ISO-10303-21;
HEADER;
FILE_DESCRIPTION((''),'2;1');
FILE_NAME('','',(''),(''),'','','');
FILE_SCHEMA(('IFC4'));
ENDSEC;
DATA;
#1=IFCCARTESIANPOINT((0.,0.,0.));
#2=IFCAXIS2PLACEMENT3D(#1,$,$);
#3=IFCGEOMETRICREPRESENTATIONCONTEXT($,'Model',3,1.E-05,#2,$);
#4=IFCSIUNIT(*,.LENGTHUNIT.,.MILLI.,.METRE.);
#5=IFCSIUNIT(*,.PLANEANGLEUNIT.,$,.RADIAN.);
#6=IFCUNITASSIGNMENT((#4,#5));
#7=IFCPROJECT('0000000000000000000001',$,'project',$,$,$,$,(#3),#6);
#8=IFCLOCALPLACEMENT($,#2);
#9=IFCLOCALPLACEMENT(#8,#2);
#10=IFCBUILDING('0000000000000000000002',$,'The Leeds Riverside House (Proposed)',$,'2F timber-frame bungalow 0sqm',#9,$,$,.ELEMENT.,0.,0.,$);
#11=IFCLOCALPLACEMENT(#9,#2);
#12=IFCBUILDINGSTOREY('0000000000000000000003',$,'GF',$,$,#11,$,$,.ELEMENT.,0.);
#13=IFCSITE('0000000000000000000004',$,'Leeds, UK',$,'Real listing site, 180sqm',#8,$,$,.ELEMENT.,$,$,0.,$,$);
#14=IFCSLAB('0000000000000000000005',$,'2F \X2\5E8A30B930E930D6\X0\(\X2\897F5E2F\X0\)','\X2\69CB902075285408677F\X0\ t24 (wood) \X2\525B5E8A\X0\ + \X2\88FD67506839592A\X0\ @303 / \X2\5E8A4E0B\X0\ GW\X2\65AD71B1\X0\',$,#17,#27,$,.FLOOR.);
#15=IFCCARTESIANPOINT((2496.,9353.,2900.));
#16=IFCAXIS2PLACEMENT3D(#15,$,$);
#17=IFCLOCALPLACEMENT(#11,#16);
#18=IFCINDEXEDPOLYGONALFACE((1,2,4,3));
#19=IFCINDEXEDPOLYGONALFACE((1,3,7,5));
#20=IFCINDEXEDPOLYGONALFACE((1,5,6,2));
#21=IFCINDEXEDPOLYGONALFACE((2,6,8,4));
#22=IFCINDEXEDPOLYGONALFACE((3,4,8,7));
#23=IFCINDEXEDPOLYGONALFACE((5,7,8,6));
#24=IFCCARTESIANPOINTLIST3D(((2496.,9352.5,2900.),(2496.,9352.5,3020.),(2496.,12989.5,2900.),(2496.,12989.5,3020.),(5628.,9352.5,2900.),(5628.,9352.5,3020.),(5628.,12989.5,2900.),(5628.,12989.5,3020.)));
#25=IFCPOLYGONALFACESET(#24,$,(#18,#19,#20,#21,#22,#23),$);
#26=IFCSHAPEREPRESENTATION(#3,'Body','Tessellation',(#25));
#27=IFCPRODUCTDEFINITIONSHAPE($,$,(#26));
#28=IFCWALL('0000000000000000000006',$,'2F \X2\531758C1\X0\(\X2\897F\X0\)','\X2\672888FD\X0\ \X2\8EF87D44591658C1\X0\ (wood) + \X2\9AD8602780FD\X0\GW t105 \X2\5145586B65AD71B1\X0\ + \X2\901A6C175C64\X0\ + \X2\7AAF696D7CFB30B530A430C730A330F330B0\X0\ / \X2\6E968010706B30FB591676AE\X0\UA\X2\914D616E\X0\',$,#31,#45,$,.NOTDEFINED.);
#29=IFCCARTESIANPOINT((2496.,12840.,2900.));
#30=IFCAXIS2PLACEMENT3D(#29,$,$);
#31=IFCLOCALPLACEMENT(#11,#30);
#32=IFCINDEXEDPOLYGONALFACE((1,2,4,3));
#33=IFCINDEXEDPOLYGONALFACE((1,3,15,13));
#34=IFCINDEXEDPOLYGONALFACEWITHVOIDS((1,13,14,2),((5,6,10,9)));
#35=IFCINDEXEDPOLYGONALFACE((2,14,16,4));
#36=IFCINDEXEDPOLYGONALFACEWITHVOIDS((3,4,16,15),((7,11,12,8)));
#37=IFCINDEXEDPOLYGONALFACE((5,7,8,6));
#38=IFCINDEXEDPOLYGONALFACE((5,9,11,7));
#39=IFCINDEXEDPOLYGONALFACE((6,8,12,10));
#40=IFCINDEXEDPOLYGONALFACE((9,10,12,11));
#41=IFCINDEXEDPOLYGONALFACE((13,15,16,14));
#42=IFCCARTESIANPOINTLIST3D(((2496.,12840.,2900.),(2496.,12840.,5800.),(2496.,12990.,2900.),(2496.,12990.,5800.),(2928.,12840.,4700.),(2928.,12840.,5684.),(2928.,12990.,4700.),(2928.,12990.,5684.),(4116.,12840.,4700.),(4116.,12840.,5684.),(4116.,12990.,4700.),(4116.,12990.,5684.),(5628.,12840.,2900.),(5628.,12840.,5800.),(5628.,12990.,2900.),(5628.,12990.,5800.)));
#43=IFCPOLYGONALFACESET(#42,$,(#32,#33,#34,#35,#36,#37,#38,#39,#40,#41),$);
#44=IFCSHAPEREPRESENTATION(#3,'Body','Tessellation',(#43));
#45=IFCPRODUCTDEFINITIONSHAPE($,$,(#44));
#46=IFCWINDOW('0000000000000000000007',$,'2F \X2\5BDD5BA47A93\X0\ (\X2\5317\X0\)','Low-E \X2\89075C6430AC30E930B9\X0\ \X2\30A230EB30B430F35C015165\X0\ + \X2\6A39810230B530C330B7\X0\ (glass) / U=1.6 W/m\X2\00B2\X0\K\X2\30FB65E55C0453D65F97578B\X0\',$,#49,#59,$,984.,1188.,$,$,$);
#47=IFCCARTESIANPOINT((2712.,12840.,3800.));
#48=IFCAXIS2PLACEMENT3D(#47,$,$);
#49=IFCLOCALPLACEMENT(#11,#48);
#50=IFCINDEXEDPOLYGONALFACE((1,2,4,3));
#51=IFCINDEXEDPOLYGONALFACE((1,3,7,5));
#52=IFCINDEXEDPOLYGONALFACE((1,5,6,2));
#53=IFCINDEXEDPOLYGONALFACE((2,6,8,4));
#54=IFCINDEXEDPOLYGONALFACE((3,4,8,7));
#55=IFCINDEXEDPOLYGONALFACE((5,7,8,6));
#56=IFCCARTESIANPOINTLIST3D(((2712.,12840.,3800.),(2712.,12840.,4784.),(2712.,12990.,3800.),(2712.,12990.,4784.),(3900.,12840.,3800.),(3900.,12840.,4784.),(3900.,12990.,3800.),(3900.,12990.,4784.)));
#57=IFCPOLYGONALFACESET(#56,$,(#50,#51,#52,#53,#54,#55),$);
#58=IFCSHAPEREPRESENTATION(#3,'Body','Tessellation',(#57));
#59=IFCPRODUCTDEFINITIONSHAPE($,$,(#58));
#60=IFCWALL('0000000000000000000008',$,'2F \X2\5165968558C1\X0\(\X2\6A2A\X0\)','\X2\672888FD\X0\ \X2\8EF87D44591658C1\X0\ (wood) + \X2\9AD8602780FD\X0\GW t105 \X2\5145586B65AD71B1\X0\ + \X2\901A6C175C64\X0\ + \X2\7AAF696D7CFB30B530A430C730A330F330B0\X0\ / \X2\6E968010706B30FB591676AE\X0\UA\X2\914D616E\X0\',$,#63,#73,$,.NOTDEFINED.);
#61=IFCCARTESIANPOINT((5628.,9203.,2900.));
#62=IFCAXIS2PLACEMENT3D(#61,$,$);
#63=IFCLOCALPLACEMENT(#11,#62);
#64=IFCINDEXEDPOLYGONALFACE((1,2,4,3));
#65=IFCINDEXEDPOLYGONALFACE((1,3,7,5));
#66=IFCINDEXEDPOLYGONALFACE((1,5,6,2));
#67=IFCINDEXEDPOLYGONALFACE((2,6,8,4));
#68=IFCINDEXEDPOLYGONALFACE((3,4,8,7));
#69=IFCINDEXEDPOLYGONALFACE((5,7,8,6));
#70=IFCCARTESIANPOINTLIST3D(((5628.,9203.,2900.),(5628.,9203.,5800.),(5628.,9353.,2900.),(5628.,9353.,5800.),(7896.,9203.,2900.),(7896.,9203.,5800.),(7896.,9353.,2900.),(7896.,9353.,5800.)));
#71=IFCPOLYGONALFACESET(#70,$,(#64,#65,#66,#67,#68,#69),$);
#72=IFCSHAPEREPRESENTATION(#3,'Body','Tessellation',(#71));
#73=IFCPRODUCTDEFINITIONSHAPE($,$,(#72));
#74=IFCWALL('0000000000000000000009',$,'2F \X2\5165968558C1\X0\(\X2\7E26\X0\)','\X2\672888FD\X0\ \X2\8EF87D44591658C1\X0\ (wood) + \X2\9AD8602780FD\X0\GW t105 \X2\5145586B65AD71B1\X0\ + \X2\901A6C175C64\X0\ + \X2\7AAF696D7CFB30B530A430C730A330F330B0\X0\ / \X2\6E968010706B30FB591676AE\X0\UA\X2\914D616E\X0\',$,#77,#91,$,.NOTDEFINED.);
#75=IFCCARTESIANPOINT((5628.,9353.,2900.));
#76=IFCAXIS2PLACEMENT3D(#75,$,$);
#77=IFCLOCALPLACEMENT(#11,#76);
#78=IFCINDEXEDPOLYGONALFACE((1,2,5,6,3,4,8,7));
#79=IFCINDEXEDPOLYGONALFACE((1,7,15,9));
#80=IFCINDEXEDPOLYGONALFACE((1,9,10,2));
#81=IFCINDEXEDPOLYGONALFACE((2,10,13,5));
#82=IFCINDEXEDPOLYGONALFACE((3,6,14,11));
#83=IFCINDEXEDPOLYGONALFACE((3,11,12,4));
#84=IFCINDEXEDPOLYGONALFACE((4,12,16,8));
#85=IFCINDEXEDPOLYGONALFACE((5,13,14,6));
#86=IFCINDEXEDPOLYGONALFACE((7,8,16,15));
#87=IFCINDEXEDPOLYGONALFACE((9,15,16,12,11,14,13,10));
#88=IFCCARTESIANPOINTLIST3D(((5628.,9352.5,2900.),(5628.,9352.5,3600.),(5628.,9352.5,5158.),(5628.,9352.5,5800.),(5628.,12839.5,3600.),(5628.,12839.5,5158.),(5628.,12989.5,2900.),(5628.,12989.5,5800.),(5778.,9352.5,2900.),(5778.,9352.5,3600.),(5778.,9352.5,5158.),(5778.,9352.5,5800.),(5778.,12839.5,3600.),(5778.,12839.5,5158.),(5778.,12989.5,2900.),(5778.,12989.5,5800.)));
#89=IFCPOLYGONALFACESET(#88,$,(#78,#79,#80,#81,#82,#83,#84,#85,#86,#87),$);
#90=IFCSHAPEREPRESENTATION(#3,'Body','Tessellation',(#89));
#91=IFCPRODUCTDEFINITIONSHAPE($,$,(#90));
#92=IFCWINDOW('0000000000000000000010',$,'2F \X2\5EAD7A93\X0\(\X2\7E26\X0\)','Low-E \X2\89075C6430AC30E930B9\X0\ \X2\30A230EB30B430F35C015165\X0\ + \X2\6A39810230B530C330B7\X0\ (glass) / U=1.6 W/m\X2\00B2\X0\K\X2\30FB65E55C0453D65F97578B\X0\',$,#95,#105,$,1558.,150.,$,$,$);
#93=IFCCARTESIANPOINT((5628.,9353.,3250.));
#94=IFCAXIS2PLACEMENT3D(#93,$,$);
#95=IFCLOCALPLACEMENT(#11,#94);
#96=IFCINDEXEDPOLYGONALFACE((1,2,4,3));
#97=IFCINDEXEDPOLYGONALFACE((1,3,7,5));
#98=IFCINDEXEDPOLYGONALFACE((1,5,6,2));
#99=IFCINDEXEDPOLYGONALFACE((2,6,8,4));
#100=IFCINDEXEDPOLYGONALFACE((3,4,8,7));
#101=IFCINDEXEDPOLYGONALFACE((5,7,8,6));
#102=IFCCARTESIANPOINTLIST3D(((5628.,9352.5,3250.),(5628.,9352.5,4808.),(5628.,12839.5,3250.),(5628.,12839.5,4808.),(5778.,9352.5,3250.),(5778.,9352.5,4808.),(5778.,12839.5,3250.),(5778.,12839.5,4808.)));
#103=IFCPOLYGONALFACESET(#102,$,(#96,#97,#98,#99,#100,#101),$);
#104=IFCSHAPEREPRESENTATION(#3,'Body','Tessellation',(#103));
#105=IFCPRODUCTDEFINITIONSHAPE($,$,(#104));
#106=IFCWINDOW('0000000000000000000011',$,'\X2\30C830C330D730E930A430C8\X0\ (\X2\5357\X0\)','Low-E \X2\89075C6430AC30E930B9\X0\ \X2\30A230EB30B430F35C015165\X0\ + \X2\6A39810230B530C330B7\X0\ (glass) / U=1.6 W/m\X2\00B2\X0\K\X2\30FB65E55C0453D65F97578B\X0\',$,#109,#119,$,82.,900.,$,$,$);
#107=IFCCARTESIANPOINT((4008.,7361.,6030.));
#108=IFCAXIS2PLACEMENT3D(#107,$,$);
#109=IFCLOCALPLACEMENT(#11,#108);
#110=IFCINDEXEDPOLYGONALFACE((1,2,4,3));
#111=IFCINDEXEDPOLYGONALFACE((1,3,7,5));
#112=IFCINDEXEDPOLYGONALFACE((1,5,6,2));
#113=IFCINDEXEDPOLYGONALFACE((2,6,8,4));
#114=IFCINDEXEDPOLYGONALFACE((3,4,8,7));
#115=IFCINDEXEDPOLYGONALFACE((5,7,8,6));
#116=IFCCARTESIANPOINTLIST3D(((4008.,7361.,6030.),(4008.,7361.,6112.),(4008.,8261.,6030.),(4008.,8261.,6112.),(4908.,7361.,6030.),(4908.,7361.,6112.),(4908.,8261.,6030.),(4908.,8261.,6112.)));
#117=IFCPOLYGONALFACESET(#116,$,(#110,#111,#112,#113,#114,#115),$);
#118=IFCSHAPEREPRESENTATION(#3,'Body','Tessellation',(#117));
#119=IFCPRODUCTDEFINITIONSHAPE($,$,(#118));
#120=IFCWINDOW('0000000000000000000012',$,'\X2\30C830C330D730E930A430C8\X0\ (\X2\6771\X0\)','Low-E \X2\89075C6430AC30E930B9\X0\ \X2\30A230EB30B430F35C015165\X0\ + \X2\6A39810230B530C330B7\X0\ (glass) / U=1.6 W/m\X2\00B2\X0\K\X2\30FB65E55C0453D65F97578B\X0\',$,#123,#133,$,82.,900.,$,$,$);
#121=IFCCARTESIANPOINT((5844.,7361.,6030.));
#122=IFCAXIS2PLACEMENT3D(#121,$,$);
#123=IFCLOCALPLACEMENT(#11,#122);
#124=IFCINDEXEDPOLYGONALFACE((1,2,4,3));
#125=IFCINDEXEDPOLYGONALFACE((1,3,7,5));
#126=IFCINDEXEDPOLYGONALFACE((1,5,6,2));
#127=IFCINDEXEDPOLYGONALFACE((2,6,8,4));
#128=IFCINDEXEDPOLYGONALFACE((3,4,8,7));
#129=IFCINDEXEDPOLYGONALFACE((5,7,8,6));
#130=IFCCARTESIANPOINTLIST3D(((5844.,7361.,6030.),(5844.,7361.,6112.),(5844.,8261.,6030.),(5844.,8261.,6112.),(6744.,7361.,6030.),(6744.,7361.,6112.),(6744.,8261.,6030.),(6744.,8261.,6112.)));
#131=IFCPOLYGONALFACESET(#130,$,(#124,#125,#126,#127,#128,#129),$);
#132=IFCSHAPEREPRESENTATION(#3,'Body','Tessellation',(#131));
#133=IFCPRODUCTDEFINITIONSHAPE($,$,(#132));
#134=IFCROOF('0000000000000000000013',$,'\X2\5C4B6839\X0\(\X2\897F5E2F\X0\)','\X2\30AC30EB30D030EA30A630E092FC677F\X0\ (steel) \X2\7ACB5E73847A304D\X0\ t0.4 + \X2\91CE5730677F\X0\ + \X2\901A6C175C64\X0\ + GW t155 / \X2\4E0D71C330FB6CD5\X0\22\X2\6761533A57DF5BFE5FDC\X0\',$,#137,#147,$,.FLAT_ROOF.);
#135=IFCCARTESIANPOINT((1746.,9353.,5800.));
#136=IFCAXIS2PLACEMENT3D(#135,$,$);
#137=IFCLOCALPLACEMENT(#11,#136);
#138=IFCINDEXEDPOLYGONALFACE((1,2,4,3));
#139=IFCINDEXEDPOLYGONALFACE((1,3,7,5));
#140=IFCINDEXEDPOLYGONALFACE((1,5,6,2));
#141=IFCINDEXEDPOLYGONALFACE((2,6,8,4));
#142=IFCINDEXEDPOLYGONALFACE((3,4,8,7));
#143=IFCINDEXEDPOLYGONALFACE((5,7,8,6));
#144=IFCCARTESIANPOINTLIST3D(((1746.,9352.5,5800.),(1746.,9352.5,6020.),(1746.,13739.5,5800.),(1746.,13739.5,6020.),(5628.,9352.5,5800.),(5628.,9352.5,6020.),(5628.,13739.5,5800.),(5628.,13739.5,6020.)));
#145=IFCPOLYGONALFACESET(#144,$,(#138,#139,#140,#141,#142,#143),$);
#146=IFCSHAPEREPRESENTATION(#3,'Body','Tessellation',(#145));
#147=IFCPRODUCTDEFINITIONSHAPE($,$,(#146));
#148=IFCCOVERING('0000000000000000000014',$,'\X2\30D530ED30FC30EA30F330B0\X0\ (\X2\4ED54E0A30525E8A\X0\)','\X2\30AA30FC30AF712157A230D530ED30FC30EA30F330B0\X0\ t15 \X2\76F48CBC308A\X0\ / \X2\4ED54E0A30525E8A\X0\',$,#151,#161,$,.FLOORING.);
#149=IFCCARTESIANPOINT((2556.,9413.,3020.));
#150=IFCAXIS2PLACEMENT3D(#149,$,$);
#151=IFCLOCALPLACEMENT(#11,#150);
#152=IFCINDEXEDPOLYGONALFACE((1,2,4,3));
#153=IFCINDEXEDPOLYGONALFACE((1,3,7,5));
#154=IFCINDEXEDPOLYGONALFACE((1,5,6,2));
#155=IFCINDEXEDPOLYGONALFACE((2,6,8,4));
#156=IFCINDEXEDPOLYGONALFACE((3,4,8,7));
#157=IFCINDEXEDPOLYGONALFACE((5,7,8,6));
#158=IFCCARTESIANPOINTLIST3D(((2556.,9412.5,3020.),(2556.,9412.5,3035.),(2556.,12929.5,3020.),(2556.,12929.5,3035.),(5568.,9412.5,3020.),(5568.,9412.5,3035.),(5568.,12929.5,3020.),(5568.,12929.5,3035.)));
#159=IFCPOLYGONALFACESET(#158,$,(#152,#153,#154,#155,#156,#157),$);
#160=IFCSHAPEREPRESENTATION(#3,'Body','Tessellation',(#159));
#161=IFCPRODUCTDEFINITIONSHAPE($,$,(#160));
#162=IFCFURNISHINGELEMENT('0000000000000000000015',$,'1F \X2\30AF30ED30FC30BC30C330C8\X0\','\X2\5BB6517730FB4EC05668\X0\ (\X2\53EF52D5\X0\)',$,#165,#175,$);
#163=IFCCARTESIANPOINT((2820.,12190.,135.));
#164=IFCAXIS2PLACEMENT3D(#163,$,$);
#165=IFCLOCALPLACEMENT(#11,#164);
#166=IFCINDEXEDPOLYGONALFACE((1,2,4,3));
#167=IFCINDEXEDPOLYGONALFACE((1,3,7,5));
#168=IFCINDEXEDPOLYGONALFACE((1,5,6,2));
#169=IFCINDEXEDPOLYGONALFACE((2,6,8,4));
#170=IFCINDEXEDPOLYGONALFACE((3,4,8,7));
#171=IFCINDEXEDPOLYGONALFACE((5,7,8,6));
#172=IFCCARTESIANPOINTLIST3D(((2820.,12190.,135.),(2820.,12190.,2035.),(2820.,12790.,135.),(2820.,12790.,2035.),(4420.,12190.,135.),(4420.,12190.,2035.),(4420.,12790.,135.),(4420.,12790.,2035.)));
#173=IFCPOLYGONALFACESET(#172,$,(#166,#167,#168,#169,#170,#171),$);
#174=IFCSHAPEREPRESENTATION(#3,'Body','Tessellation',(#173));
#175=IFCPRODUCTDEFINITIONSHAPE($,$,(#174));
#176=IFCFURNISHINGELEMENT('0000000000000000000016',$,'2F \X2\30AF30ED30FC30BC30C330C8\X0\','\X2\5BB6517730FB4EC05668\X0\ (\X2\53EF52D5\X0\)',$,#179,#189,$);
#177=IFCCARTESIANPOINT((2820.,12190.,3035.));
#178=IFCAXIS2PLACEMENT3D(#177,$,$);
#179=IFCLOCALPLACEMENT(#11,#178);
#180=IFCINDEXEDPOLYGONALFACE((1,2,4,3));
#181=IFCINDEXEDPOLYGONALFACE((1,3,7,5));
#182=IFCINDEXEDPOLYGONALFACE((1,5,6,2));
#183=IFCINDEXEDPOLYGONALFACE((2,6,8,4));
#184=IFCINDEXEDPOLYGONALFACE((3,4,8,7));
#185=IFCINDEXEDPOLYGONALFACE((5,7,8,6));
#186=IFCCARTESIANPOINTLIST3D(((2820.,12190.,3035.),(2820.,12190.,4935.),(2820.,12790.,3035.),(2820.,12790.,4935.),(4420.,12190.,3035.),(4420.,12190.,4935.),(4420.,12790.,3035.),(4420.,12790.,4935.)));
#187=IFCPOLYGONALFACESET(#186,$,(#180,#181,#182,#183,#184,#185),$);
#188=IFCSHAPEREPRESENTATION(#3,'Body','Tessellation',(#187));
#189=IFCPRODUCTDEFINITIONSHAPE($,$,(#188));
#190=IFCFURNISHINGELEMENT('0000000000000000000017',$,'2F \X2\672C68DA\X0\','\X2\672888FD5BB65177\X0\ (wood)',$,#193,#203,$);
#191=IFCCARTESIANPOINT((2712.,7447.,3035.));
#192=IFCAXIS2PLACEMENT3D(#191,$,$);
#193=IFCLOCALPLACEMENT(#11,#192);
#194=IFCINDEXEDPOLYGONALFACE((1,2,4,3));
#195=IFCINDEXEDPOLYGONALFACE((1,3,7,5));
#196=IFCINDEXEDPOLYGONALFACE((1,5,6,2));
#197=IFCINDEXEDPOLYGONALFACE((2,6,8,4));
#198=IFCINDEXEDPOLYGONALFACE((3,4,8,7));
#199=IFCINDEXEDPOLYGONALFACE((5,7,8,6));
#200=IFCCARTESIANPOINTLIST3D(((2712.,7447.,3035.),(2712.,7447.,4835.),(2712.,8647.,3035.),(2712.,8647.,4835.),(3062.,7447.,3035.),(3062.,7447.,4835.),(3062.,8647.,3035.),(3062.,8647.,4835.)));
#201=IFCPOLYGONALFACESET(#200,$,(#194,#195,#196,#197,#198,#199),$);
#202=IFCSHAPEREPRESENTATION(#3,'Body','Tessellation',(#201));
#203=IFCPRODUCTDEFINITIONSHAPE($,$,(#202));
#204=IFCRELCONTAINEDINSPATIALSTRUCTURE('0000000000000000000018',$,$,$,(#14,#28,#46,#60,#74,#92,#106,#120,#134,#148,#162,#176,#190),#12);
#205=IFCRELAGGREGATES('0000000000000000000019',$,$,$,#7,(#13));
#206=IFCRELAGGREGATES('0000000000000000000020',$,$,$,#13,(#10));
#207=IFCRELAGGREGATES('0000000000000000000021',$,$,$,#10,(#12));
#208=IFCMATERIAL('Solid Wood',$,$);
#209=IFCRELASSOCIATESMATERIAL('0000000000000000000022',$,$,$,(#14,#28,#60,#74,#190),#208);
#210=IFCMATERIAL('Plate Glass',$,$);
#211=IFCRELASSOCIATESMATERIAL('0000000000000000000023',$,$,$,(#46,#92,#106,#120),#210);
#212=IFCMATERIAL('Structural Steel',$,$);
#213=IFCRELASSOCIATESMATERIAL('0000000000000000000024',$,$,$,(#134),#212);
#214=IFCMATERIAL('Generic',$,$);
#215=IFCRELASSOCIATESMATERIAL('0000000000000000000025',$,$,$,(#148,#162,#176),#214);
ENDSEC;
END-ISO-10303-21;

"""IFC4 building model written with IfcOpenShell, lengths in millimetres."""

from ifc_helpers import new_model, si_unit, frame, frame_2d, origin, place, context, project, spatial, rectangle, extrude, material, element, fill, save


model = new_model("IFC4")

# Units and contexts
model_context = context("Model", 3, precision=1e-05, world=origin())
ifc_project = project(units=[si_unit("LENGTHUNIT", "METRE", prefix="MILLI"), si_unit("PLANEANGLEUNIT", "RADIAN")], contexts=[model_context])

# Site, building, storey
site_placement = place(None, origin())
site = spatial("IfcSite", under=ifc_project, at=site_placement, Name="Leeds, UK", ObjectType="Real listing site, 180sqm", CompositionType="ELEMENT", RefElevation=0.0)
building_placement = place(site_placement, origin())
building = spatial("IfcBuilding", under=site, at=building_placement, Name="The Leeds Riverside House (Proposed)", ObjectType="2F timber-frame bungalow 0sqm", CompositionType="ELEMENT", ElevationOfRefHeight=0.0, ElevationOfTerrain=0.0)
storey_placement = place(building_placement, origin())
storey = spatial("IfcBuildingStorey", under=building, at=storey_placement, Name="GF", CompositionType="ELEMENT", Elevation=0.0)

# Slab
ifc_material_1 = material(Name="Solid Wood")
slab_placement = place(storey_placement, frame((2496.0, 9353.0, 2900.0)))
element("IfcSlab", 1, at=slab_placement, inside=storey, material=ifc_material_1, Name="2F 床スラブ(西帯)", Description="構造用合板 t24 (wood) 剛床 + 製材根太 @303 / 床下 GW断熱", PredefinedType="FLOOR", context=model_context, shape_type="SweptSolid", body=[
    extrude(rectangle(XDim=3132.0, YDim=3637.0, at=frame_2d((1566.0, 1818.0))), frame((2496.0, 9353.0, 2900.0)), (0.0, 0.0, 1.0), 120.0),
])

# Wall, opening, window
wall_1_placement = place(storey_placement, frame((2496.0, 12840.0, 2900.0)))
wall_1 = element("IfcWall", 2, at=wall_1_placement, inside=storey, material=ifc_material_1, Name="2F 北壁(西)", Description="木製 軸組外壁 (wood) + 高性能GW t105 充填断熱 + 通気層 + 窯業系サイディング / 準耐火・外皮UA配慮", PredefinedType="NOTDEFINED", context=model_context, shape_type="SweptSolid", body=[
    extrude(rectangle(XDim=3132.0, YDim=150.0, at=frame_2d((1566.0, 75.0))), frame((2496.0, 12840.0, 2900.0)), (0.0, 0.0, 1.0), 2900.0),
])
opening_1_placement = place(storey_placement, frame((2712.0, 12840.0, 3800.0)))
opening_1 = element("IfcOpeningElement", 3, at=opening_1_placement, cuts=wall_1, PredefinedType="NOTDEFINED", context=model_context, shape_type="SweptSolid", body=[
    extrude(rectangle(XDim=1188.0, YDim=150.0, at=frame_2d((594.0, 75.0))), frame((2712.0, 12840.0, 3800.0)), (0.0, 0.0, 1.0), 984.0),
])
ifc_material_2 = material(Name="Plate Glass")
window_1_placement = place(storey_placement, frame((2712.0, 12840.0, 3800.0)))
window_1 = element("IfcWindow", 4, at=window_1_placement, inside=storey, material=ifc_material_2, Name="2F 寝室窓 (北)", Description="Low-E 複層ガラス アルゴン封入 + 樹脂サッシ (glass) / U=1.6 W/m²K・日射取得型", OverallHeight=984.0, OverallWidth=1188.0, context=model_context, shape_type="SweptSolid", body=[
    extrude(rectangle(XDim=1188.0, YDim=150.0, at=frame_2d((594.0, 75.0))), frame((2712.0, 12840.0, 3800.0)), (0.0, 0.0, 1.0), 984.0),
])
fill(opening_1, window_1)

# Wall
wall_2_placement = place(storey_placement, frame((5628.0, 9203.0, 2900.0)))
element("IfcWall", 5, at=wall_2_placement, inside=storey, material=ifc_material_1, Name="2F 入隅壁(横)", Description="木製 軸組外壁 (wood) + 高性能GW t105 充填断熱 + 通気層 + 窯業系サイディング / 準耐火・外皮UA配慮", PredefinedType="NOTDEFINED", context=model_context, shape_type="SweptSolid", body=[
    extrude(rectangle(XDim=2268.0, YDim=150.0, at=frame_2d((1134.0, 75.0))), frame((5628.0, 9203.0, 2900.0)), (0.0, 0.0, 1.0), 2900.0),
])

# Wall, opening, window
wall_3_placement = place(storey_placement, frame((5628.0, 9353.0, 2900.0)))
wall_3 = element("IfcWall", 6, at=wall_3_placement, inside=storey, material=ifc_material_1, Name="2F 入隅壁(縦)", Description="木製 軸組外壁 (wood) + 高性能GW t105 充填断熱 + 通気層 + 窯業系サイディング / 準耐火・外皮UA配慮", PredefinedType="NOTDEFINED", context=model_context, shape_type="SweptSolid", body=[
    extrude(rectangle(XDim=150.0, YDim=3637.0, at=frame_2d((75.0, 1818.0))), frame((5628.0, 9353.0, 2900.0)), (0.0, 0.0, 1.0), 2900.0),
])
opening_2_placement = place(storey_placement, frame((5628.0, 9353.0, 3250.0)))
opening_2 = element("IfcOpeningElement", 7, at=opening_2_placement, cuts=wall_3, PredefinedType="NOTDEFINED", context=model_context, shape_type="SweptSolid", body=[
    extrude(rectangle(XDim=150.0, YDim=3487.0, at=frame_2d((75.0, 1743.0))), frame((5628.0, 9353.0, 3250.0)), (0.0, 0.0, 1.0), 1558.0),
])
window_2_placement = place(storey_placement, frame((5628.0, 9353.0, 3250.0)))
window_2 = element("IfcWindow", 8, at=window_2_placement, inside=storey, material=ifc_material_2, Name="2F 庭窓(縦)", Description="Low-E 複層ガラス アルゴン封入 + 樹脂サッシ (glass) / U=1.6 W/m²K・日射取得型", OverallHeight=1558.0, OverallWidth=150.0, context=model_context, shape_type="SweptSolid", body=[
    extrude(rectangle(XDim=150.0, YDim=3487.0, at=frame_2d((75.0, 1743.0))), frame((5628.0, 9353.0, 3250.0)), (0.0, 0.0, 1.0), 1558.0),
])
fill(opening_2, window_2)

# Windows
window_3_placement = place(storey_placement, frame((4008.0, 7361.0, 6030.0)))
element("IfcWindow", 9, at=window_3_placement, inside=storey, material=ifc_material_2, Name="トップライト (南)", Description="Low-E 複層ガラス アルゴン封入 + 樹脂サッシ (glass) / U=1.6 W/m²K・日射取得型", OverallHeight=82.0, OverallWidth=900.0, context=model_context, shape_type="SweptSolid", body=[
    extrude(rectangle(XDim=900.0, YDim=900.0, at=frame_2d((450.0, 450.0))), frame((4008.0, 7361.0, 6030.0)), (0.0, 0.0, 1.0), 82.0),
])
window_4_placement = place(storey_placement, frame((5844.0, 7361.0, 6030.0)))
element("IfcWindow", 10, at=window_4_placement, inside=storey, material=ifc_material_2, Name="トップライト (東)", Description="Low-E 複層ガラス アルゴン封入 + 樹脂サッシ (glass) / U=1.6 W/m²K・日射取得型", OverallHeight=82.0, OverallWidth=900.0, context=model_context, shape_type="SweptSolid", body=[
    extrude(rectangle(XDim=900.0, YDim=900.0, at=frame_2d((450.0, 450.0))), frame((5844.0, 7361.0, 6030.0)), (0.0, 0.0, 1.0), 82.0),
])

# Roof
ifc_material_3 = material(Name="Structural Steel")
for number, where, name in (
    (11, (1746.0, 9353.0, 5800.0), "屋根(西帯)"),
):
    element("IfcRoof", number, at=place(storey_placement, frame(where)), inside=storey, material=ifc_material_3, Name=name, Description="ガルバリウム鋼板 (steel) 立平葺き t0.4 + 野地板 + 通気層 + GW t155 / 不燃・法22条区域対応", PredefinedType="FLAT_ROOF", context=model_context, shape_type="SweptSolid", body=[
        extrude(rectangle(XDim=3882.0, YDim=4387.0, at=frame_2d((1941.0, 2193.0))), frame((1746.0, 9353.0, 5800.0)), (0.0, 0.0, 1.0), 220.0),
    ])

# Covering
ifc_material_4 = material(Name="Generic")
covering_placement = place(storey_placement, frame((2556.0, 9413.0, 3020.0)))
element("IfcCovering", 12, at=covering_placement, inside=storey, material=ifc_material_4, Name="フローリング (仕上げ床)", Description="オーク無垢フローリング t15 直貼り / 仕上げ床", PredefinedType="FLOORING", context=model_context, shape_type="SweptSolid", body=[
    extrude(rectangle(XDim=3012.0, YDim=3517.0, at=frame_2d((1506.0, 1758.0))), frame((2556.0, 9413.0, 3020.0)), (0.0, 0.0, 1.0), 15.0),
])

# Furnishing elements
furnishing_1_placement = place(storey_placement, frame((2820.0, 12190.0, 135.0)))
element("IfcFurnishingElement", 13, at=furnishing_1_placement, inside=storey, material=ifc_material_4, Name="1F クローゼット", Description="家具・什器 (可動)", context=model_context, shape_type="SweptSolid", body=[
    extrude(rectangle(XDim=1600.0, YDim=600.0, at=frame_2d((800.0, 300.0))), frame((2820.0, 12190.0, 135.0)), (0.0, 0.0, 1.0), 1900.0),
])
furnishing_2_placement = place(storey_placement, frame((2820.0, 12190.0, 3035.0)))
element("IfcFurnishingElement", 14, at=furnishing_2_placement, inside=storey, material=ifc_material_4, Name="2F クローゼット", Description="家具・什器 (可動)", context=model_context, shape_type="SweptSolid", body=[
    extrude(rectangle(XDim=1600.0, YDim=600.0, at=frame_2d((800.0, 300.0))), frame((2820.0, 12190.0, 3035.0)), (0.0, 0.0, 1.0), 1900.0),
])
furnishing_3_placement = place(storey_placement, frame((2712.0, 7447.0, 3035.0)))
element("IfcFurnishingElement", 15, at=furnishing_3_placement, inside=storey, material=ifc_material_1, Name="2F 本棚", Description="木製家具 (wood)", context=model_context, shape_type="SweptSolid", body=[
    extrude(rectangle(XDim=350.0, YDim=1200.0, at=frame_2d((175.0, 600.0))), frame((2712.0, 7447.0, 3035.0)), (0.0, 0.0, 1.0), 1800.0),
])

save(model, "model.ifc")
